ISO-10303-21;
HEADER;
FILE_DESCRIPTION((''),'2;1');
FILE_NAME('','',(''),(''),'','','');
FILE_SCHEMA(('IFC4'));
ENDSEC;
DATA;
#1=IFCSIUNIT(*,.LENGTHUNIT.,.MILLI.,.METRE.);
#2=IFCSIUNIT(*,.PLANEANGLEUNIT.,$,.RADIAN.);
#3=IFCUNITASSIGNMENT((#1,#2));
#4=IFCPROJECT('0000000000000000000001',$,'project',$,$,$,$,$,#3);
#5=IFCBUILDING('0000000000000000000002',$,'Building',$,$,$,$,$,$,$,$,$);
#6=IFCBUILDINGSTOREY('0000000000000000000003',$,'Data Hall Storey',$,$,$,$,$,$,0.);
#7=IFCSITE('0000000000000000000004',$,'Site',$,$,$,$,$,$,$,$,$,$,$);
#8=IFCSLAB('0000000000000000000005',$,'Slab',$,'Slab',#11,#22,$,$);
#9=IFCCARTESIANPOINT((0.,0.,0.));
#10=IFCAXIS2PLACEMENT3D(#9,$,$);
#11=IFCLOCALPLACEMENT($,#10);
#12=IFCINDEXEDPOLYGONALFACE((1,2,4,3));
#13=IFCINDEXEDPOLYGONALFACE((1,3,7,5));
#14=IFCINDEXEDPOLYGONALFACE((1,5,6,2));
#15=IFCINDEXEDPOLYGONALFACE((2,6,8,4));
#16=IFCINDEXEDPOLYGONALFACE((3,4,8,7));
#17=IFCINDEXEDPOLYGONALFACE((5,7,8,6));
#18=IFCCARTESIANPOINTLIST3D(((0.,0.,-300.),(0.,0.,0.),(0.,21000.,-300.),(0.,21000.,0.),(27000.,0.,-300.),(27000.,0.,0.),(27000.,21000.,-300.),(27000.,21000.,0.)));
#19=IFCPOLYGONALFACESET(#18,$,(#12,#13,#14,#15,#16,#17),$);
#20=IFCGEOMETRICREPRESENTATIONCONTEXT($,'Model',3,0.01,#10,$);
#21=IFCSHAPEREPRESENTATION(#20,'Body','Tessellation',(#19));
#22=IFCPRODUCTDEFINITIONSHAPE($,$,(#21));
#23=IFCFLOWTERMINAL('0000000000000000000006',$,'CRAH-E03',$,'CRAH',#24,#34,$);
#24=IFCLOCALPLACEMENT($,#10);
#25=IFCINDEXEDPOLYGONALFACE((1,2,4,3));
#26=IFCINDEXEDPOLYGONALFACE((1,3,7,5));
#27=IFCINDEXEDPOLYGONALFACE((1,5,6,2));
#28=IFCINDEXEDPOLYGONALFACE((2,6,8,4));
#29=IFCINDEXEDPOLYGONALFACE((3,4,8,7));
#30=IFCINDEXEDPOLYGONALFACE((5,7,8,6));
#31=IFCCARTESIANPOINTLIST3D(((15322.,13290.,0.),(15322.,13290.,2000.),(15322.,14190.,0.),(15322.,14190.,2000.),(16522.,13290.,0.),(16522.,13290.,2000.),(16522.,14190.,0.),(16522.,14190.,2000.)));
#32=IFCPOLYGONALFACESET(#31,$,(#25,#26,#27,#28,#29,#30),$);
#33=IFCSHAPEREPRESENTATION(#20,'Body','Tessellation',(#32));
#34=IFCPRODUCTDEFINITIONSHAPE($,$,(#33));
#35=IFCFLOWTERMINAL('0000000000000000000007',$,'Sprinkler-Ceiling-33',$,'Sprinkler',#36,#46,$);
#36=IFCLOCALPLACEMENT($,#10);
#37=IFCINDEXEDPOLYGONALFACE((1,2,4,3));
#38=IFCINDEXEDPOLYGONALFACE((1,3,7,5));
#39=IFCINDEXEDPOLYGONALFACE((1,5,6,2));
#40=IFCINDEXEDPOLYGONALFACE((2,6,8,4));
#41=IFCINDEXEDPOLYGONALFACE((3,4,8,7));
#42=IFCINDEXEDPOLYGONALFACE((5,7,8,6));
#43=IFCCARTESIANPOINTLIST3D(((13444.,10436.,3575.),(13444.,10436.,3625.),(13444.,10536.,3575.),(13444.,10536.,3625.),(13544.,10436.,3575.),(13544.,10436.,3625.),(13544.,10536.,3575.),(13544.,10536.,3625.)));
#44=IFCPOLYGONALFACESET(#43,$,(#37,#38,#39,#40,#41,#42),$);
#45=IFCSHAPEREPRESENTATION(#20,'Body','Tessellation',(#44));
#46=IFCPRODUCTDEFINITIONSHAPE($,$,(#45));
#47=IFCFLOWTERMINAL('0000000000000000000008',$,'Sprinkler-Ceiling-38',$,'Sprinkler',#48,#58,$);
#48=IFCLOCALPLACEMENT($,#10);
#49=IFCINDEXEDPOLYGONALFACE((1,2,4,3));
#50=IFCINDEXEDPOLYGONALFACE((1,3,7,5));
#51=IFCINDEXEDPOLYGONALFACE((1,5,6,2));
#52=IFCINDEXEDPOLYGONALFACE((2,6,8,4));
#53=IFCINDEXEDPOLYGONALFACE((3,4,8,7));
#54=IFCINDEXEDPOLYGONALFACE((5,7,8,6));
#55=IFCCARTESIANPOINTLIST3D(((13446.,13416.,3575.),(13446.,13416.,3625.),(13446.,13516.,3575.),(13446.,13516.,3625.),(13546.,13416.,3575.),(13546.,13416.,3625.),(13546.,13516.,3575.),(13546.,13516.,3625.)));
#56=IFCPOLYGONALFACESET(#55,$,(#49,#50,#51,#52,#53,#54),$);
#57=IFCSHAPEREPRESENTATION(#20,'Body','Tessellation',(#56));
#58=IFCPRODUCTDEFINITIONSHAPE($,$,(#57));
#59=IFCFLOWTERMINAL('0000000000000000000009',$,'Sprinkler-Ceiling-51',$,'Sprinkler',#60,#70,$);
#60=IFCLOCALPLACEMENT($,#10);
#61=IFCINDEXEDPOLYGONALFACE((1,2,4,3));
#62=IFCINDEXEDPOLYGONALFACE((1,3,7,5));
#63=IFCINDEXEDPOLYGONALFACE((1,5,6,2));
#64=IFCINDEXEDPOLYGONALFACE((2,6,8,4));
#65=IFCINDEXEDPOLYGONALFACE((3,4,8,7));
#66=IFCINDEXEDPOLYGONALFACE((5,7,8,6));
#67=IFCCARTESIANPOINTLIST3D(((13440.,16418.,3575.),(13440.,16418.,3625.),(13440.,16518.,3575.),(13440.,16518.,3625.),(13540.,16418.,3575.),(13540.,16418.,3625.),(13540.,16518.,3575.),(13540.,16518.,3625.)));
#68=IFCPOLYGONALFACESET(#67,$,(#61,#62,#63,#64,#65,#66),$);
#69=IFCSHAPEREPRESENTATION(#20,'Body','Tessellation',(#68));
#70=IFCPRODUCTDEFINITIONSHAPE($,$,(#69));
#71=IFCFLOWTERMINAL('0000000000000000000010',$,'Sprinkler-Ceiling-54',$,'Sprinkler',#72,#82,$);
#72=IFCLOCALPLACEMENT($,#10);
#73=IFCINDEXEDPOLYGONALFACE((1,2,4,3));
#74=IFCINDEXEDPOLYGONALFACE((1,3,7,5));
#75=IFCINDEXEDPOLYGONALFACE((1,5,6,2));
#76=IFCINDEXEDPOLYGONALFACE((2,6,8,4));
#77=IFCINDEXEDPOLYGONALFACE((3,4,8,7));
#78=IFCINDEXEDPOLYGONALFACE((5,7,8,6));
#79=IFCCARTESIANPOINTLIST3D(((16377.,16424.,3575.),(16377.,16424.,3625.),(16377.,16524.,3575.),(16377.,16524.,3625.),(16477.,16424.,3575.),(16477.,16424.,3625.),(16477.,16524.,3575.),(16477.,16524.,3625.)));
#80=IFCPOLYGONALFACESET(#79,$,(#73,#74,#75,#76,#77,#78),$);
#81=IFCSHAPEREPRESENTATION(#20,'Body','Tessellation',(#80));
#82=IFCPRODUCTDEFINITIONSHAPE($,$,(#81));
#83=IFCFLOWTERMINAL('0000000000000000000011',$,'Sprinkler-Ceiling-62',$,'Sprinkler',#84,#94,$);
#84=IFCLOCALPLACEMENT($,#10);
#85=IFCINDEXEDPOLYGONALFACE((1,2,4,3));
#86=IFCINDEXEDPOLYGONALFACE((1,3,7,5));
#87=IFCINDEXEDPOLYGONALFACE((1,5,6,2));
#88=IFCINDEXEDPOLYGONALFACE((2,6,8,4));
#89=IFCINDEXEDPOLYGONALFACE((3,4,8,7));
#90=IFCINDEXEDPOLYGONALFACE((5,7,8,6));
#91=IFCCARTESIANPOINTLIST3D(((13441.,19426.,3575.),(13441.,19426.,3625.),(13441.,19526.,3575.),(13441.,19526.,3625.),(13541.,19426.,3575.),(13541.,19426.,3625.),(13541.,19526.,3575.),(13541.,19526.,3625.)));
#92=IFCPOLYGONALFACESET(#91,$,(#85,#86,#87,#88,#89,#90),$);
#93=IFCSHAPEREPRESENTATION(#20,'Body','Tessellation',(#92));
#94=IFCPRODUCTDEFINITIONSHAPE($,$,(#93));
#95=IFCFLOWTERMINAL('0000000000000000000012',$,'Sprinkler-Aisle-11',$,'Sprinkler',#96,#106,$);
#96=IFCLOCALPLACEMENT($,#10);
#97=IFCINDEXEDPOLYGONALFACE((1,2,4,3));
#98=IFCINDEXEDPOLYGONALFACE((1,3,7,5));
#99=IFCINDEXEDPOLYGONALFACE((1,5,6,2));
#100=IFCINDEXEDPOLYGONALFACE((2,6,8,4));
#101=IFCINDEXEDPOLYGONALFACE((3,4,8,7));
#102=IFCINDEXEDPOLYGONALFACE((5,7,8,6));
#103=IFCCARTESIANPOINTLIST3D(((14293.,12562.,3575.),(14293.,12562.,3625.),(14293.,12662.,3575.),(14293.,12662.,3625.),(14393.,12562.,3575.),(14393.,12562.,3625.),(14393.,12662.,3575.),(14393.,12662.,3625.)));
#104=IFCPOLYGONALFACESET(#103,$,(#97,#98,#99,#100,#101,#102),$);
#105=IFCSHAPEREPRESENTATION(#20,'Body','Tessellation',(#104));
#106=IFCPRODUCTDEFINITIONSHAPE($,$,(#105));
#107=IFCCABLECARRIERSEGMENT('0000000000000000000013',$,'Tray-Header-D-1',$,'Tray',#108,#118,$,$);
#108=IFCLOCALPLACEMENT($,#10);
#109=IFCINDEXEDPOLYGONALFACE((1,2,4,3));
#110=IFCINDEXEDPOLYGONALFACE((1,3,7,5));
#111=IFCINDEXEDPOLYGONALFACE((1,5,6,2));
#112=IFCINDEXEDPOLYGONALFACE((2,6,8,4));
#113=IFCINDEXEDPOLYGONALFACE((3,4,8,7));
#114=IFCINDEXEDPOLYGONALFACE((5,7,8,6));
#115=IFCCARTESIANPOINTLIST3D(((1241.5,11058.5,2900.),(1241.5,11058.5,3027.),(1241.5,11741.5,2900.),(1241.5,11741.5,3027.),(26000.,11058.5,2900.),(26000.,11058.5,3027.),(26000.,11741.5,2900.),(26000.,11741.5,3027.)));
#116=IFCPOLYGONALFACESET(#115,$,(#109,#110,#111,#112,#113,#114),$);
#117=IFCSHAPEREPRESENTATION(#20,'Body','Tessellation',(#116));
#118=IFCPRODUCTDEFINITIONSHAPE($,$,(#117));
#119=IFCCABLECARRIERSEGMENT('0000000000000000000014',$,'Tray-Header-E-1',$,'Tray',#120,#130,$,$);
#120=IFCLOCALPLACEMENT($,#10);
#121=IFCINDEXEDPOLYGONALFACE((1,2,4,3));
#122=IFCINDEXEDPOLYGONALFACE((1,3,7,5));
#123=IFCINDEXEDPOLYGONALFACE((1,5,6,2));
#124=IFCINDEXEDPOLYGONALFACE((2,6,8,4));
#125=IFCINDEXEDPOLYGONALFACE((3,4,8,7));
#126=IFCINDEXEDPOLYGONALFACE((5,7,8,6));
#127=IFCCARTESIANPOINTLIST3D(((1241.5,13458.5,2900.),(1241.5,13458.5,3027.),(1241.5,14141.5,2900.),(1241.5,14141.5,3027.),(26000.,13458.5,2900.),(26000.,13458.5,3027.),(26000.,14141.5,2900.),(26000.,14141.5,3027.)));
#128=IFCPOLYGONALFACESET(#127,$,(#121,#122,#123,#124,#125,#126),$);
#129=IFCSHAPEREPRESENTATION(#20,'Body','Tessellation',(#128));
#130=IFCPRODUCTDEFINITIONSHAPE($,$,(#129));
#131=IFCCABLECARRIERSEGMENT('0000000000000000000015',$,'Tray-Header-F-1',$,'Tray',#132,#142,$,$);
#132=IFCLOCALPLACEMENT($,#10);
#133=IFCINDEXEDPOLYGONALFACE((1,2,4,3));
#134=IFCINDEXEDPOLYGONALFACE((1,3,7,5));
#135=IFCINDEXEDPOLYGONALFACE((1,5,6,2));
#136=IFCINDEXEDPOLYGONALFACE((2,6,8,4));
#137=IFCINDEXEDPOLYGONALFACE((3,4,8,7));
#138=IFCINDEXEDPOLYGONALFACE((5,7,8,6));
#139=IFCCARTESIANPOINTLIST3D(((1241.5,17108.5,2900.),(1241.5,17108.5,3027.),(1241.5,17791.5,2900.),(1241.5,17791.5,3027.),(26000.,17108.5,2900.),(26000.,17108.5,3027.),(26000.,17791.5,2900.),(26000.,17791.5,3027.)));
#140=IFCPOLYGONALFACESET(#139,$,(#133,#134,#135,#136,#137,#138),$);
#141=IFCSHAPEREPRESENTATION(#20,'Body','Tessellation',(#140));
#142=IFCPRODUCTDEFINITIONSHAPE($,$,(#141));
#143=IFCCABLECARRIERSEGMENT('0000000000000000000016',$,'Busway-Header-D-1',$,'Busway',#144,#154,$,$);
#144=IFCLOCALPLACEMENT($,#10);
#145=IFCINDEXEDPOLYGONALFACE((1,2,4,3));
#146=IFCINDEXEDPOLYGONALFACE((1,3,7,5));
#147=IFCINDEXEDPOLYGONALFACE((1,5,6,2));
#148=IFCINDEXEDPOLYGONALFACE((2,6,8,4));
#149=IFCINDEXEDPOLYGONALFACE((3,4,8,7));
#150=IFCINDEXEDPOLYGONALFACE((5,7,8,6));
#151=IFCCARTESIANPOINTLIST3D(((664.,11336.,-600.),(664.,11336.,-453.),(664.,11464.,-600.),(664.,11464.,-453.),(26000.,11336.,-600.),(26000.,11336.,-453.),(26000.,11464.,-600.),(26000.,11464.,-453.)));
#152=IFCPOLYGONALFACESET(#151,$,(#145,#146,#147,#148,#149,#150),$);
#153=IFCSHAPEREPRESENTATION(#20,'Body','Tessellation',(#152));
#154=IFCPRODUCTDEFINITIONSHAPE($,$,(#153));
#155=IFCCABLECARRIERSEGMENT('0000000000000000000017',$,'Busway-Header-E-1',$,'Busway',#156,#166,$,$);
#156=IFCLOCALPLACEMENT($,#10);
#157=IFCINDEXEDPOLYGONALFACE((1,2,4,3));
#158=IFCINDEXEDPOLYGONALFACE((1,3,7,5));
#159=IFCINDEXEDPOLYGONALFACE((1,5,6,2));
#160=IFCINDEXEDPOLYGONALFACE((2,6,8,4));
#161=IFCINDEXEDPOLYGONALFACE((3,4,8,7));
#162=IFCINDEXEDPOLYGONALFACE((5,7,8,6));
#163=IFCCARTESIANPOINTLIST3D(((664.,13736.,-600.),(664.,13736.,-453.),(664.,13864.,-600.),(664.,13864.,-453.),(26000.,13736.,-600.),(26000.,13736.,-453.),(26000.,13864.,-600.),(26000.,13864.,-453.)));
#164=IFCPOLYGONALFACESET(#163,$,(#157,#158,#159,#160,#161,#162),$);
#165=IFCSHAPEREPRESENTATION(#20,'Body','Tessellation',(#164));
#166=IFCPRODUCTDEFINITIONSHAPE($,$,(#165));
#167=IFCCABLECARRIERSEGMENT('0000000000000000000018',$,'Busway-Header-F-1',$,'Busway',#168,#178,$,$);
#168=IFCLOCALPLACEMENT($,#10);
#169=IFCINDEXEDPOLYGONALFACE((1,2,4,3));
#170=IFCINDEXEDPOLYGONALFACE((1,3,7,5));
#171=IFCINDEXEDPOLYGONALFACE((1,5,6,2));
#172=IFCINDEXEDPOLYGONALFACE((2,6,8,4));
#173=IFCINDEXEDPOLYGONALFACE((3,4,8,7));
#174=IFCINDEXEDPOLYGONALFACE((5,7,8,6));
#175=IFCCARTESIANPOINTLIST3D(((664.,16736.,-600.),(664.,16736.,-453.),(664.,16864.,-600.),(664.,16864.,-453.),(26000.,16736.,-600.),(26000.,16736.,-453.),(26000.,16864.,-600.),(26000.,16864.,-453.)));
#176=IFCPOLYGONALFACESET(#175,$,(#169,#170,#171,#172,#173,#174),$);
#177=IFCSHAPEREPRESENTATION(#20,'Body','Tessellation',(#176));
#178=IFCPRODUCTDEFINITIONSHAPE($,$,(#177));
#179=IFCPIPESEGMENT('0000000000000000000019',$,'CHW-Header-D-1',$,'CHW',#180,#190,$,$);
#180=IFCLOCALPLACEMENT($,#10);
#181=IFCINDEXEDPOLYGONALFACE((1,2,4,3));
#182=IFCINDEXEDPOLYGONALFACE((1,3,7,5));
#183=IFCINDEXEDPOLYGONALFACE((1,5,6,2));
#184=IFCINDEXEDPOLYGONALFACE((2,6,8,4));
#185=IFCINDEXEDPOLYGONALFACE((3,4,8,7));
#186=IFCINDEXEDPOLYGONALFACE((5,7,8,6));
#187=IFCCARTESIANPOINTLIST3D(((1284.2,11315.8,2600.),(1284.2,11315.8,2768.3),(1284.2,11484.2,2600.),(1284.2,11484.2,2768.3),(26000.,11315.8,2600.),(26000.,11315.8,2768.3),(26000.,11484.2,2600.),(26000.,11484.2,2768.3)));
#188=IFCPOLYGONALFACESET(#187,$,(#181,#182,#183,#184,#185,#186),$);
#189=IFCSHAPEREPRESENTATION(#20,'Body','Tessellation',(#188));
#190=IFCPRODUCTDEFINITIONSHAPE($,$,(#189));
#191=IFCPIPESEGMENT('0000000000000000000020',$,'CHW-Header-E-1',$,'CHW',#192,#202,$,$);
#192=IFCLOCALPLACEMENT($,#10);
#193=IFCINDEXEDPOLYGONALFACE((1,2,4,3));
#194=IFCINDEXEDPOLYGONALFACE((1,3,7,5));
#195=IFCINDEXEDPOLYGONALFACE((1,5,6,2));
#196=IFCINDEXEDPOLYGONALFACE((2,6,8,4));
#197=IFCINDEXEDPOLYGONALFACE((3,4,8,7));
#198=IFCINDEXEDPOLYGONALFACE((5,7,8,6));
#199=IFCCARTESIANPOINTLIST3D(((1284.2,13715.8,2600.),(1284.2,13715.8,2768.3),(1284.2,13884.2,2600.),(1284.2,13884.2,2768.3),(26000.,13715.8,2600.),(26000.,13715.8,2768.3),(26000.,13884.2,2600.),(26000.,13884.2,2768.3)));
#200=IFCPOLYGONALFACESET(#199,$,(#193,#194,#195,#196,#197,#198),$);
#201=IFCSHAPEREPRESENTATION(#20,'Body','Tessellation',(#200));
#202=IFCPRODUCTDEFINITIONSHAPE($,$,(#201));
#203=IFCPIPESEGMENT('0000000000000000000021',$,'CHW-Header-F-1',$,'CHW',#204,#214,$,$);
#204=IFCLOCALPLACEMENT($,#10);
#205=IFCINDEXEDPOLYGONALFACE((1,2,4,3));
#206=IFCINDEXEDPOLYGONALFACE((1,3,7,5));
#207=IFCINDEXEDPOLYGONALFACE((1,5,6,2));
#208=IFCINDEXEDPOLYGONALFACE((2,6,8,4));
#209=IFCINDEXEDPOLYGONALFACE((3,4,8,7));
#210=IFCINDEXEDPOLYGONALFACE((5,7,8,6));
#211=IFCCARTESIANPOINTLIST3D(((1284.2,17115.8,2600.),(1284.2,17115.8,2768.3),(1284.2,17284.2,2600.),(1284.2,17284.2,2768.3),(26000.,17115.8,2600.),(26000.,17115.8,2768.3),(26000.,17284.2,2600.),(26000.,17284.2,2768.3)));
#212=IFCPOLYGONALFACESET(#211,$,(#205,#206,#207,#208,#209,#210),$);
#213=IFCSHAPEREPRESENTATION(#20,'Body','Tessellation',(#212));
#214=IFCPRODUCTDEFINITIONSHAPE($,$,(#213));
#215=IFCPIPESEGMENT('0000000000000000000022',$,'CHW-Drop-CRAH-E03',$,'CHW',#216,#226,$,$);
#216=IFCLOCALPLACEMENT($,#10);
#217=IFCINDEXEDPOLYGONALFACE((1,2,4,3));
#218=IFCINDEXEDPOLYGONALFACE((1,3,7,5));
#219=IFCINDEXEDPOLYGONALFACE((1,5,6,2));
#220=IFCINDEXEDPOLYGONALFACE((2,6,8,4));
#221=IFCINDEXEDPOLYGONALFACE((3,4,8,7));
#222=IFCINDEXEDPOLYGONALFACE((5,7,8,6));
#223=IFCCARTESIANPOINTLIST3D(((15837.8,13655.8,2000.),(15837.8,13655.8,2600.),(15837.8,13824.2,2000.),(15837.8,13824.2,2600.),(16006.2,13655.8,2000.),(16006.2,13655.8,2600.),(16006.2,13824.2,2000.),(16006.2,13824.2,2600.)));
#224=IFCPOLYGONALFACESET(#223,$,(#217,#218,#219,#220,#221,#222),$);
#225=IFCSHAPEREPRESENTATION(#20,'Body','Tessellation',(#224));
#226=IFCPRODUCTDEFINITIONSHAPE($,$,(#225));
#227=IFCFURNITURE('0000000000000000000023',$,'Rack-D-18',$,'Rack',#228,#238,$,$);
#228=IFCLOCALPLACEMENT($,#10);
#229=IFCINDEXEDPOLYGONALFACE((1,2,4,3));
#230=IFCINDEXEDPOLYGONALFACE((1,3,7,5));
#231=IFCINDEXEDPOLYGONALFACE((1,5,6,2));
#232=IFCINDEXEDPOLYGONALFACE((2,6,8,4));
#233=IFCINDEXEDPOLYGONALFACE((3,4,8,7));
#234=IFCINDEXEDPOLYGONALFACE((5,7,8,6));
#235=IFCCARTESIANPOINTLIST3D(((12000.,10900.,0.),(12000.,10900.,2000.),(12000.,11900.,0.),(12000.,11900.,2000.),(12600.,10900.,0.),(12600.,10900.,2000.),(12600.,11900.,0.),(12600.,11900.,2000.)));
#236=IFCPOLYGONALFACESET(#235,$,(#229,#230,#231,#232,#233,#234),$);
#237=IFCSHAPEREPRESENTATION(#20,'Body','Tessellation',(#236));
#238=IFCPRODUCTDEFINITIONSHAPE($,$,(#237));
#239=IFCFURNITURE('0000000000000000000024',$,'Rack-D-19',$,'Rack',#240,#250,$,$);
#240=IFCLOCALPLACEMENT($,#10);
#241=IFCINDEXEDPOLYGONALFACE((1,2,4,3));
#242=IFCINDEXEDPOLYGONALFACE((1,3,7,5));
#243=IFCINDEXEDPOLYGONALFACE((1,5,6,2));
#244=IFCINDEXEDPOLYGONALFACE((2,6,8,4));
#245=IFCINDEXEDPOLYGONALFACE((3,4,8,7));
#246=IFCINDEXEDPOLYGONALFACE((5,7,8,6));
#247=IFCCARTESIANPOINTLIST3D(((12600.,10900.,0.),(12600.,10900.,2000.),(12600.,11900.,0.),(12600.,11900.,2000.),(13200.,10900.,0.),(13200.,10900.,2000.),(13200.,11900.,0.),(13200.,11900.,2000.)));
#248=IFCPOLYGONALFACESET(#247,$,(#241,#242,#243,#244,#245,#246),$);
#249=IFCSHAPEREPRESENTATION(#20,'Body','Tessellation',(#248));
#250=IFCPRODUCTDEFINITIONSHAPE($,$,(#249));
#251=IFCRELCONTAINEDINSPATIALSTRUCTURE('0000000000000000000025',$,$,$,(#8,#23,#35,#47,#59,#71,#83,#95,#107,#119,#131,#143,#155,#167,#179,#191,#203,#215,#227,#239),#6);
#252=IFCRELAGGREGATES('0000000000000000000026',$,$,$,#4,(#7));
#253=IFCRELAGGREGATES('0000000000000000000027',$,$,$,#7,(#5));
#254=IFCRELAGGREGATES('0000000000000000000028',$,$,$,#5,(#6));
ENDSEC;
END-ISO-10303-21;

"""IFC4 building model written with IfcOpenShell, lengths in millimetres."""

from ifc_helpers import new_model, si_unit, frame, origin, place, context, project, spatial, rectangle, extrude, element, save


model = new_model("IFC4")

# Units and contexts
model_context = context("Model", 3, precision=0.01, world=origin())
ifc_project = project(units=[si_unit("LENGTHUNIT", "METRE", prefix="MILLI"), si_unit("PLANEANGLEUNIT", "RADIAN")])

# Site, building, storey
site = spatial("IfcSite", under=ifc_project, Name="Site")
building = spatial("IfcBuilding", under=site, Name="Building")
storey = spatial("IfcBuildingStorey", under=building, Name="Data Hall Storey", Elevation=0.0)

# Slab
slab_placement = place(None, frame((13500.0, 10500.0, -300.0)))
element("IfcSlab", 1, at=slab_placement, inside=storey, Name="Slab", ObjectType="Slab", context=model_context, shape_type="SweptSolid", body=[
    extrude(rectangle(XDim=27000.0, YDim=21000.0), origin(), (0.0, 0.0, 1.0), 300.0),
])

# Flow terminals
flow_terminal_placement = place(None, frame((15922.0, 13740.0, 0.0)))
element("IfcFlowTerminal", 2, at=flow_terminal_placement, inside=storey, Name="CRAH-E03", ObjectType="CRAH", context=model_context, shape_type="SweptSolid", body=[
    extrude(rectangle(XDim=1200.0, YDim=900.0), origin(), (0.0, 0.0, 1.0), 2000.0),
])
for number, where, name in (
    (3, (13494.0, 10486.0, 3575.0), "Sprinkler-Ceiling-33"),
    (4, (13496.0, 13466.0, 3575.0), "Sprinkler-Ceiling-38"),
    (5, (13490.0, 16468.0, 3575.0), "Sprinkler-Ceiling-51"),
    (6, (16427.0, 16474.0, 3575.0), "Sprinkler-Ceiling-54"),
    (7, (13491.0, 19476.0, 3575.0), "Sprinkler-Ceiling-62"),
    (8, (14343.0, 12612.0, 3575.0), "Sprinkler-Aisle-11"),
):
    element("IfcFlowTerminal", number, at=place(None, frame(where)), inside=storey, Name=name, ObjectType="Sprinkler", context=model_context, shape_type="SweptSolid", body=[
        extrude(rectangle(XDim=100.0, YDim=100.0), origin(), (0.0, 0.0, 1.0), 50.0),
    ])

# Cable carrier segments
for number, where, name in (
    (9, (13620.8, 11400.0, 2900.0), "Tray-Header-D-1"),
    (10, (13620.8, 13800.0, 2900.0), "Tray-Header-E-1"),
    (11, (13620.8, 17450.0, 2900.0), "Tray-Header-F-1"),
):
    element("IfcCableCarrierSegment", number, at=place(None, frame(where)), inside=storey, Name=name, ObjectType="Tray", context=model_context, shape_type="SweptSolid", body=[
        extrude(rectangle(XDim=24758.5, YDim=683.0), origin(), (0.0, 0.0, 1.0), 127.0),
    ])
for number, where, name in (
    (12, (13332.0, 11400.0, -600.0), "Busway-Header-D-1"),
    (13, (13332.0, 13800.0, -600.0), "Busway-Header-E-1"),
    (14, (13332.0, 16800.0, -600.0), "Busway-Header-F-1"),
):
    element("IfcCableCarrierSegment", number, at=place(None, frame(where)), inside=storey, Name=name, ObjectType="Busway", context=model_context, shape_type="SweptSolid", body=[
        extrude(rectangle(XDim=25336.0, YDim=128.0), origin(), (0.0, 0.0, 1.0), 147.0),
    ])

# Pipe segments
for number, where, name in (
    (15, (13642.1, 11400.0, 2600.0), "CHW-Header-D-1"),
    (16, (13642.1, 13800.0, 2600.0), "CHW-Header-E-1"),
    (17, (13642.1, 17200.0, 2600.0), "CHW-Header-F-1"),
):
    element("IfcPipeSegment", number, at=place(None, frame(where)), inside=storey, Name=name, ObjectType="CHW", context=model_context, shape_type="SweptSolid", body=[
        extrude(rectangle(XDim=24715.8, YDim=168.3), origin(), (0.0, 0.0, 1.0), 168.3),
    ])
pipe_segment_placement = place(None, frame((15922.0, 13740.0, 2000.0)))
element("IfcPipeSegment", 18, at=pipe_segment_placement, inside=storey, Name="CHW-Drop-CRAH-E03", ObjectType="CHW", context=model_context, shape_type="SweptSolid", body=[
    extrude(rectangle(XDim=168.3, YDim=168.3), origin(), (0.0, 0.0, 1.0), 600.0),
])

# Furniture
for number, where, name in (
    (19, (12300.0, 11400.0, 0.0), "Rack-D-18"),
    (20, (12900.0, 11400.0, 0.0), "Rack-D-19"),
):
    element("IfcFurniture", number, at=place(None, frame(where)), inside=storey, Name=name, ObjectType="Rack", context=model_context, shape_type="SweptSolid", body=[
        extrude(rectangle(XDim=600.0, YDim=1000.0), origin(), (0.0, 0.0, 1.0), 2000.0),
    ])

save(model, "model.ifc")
